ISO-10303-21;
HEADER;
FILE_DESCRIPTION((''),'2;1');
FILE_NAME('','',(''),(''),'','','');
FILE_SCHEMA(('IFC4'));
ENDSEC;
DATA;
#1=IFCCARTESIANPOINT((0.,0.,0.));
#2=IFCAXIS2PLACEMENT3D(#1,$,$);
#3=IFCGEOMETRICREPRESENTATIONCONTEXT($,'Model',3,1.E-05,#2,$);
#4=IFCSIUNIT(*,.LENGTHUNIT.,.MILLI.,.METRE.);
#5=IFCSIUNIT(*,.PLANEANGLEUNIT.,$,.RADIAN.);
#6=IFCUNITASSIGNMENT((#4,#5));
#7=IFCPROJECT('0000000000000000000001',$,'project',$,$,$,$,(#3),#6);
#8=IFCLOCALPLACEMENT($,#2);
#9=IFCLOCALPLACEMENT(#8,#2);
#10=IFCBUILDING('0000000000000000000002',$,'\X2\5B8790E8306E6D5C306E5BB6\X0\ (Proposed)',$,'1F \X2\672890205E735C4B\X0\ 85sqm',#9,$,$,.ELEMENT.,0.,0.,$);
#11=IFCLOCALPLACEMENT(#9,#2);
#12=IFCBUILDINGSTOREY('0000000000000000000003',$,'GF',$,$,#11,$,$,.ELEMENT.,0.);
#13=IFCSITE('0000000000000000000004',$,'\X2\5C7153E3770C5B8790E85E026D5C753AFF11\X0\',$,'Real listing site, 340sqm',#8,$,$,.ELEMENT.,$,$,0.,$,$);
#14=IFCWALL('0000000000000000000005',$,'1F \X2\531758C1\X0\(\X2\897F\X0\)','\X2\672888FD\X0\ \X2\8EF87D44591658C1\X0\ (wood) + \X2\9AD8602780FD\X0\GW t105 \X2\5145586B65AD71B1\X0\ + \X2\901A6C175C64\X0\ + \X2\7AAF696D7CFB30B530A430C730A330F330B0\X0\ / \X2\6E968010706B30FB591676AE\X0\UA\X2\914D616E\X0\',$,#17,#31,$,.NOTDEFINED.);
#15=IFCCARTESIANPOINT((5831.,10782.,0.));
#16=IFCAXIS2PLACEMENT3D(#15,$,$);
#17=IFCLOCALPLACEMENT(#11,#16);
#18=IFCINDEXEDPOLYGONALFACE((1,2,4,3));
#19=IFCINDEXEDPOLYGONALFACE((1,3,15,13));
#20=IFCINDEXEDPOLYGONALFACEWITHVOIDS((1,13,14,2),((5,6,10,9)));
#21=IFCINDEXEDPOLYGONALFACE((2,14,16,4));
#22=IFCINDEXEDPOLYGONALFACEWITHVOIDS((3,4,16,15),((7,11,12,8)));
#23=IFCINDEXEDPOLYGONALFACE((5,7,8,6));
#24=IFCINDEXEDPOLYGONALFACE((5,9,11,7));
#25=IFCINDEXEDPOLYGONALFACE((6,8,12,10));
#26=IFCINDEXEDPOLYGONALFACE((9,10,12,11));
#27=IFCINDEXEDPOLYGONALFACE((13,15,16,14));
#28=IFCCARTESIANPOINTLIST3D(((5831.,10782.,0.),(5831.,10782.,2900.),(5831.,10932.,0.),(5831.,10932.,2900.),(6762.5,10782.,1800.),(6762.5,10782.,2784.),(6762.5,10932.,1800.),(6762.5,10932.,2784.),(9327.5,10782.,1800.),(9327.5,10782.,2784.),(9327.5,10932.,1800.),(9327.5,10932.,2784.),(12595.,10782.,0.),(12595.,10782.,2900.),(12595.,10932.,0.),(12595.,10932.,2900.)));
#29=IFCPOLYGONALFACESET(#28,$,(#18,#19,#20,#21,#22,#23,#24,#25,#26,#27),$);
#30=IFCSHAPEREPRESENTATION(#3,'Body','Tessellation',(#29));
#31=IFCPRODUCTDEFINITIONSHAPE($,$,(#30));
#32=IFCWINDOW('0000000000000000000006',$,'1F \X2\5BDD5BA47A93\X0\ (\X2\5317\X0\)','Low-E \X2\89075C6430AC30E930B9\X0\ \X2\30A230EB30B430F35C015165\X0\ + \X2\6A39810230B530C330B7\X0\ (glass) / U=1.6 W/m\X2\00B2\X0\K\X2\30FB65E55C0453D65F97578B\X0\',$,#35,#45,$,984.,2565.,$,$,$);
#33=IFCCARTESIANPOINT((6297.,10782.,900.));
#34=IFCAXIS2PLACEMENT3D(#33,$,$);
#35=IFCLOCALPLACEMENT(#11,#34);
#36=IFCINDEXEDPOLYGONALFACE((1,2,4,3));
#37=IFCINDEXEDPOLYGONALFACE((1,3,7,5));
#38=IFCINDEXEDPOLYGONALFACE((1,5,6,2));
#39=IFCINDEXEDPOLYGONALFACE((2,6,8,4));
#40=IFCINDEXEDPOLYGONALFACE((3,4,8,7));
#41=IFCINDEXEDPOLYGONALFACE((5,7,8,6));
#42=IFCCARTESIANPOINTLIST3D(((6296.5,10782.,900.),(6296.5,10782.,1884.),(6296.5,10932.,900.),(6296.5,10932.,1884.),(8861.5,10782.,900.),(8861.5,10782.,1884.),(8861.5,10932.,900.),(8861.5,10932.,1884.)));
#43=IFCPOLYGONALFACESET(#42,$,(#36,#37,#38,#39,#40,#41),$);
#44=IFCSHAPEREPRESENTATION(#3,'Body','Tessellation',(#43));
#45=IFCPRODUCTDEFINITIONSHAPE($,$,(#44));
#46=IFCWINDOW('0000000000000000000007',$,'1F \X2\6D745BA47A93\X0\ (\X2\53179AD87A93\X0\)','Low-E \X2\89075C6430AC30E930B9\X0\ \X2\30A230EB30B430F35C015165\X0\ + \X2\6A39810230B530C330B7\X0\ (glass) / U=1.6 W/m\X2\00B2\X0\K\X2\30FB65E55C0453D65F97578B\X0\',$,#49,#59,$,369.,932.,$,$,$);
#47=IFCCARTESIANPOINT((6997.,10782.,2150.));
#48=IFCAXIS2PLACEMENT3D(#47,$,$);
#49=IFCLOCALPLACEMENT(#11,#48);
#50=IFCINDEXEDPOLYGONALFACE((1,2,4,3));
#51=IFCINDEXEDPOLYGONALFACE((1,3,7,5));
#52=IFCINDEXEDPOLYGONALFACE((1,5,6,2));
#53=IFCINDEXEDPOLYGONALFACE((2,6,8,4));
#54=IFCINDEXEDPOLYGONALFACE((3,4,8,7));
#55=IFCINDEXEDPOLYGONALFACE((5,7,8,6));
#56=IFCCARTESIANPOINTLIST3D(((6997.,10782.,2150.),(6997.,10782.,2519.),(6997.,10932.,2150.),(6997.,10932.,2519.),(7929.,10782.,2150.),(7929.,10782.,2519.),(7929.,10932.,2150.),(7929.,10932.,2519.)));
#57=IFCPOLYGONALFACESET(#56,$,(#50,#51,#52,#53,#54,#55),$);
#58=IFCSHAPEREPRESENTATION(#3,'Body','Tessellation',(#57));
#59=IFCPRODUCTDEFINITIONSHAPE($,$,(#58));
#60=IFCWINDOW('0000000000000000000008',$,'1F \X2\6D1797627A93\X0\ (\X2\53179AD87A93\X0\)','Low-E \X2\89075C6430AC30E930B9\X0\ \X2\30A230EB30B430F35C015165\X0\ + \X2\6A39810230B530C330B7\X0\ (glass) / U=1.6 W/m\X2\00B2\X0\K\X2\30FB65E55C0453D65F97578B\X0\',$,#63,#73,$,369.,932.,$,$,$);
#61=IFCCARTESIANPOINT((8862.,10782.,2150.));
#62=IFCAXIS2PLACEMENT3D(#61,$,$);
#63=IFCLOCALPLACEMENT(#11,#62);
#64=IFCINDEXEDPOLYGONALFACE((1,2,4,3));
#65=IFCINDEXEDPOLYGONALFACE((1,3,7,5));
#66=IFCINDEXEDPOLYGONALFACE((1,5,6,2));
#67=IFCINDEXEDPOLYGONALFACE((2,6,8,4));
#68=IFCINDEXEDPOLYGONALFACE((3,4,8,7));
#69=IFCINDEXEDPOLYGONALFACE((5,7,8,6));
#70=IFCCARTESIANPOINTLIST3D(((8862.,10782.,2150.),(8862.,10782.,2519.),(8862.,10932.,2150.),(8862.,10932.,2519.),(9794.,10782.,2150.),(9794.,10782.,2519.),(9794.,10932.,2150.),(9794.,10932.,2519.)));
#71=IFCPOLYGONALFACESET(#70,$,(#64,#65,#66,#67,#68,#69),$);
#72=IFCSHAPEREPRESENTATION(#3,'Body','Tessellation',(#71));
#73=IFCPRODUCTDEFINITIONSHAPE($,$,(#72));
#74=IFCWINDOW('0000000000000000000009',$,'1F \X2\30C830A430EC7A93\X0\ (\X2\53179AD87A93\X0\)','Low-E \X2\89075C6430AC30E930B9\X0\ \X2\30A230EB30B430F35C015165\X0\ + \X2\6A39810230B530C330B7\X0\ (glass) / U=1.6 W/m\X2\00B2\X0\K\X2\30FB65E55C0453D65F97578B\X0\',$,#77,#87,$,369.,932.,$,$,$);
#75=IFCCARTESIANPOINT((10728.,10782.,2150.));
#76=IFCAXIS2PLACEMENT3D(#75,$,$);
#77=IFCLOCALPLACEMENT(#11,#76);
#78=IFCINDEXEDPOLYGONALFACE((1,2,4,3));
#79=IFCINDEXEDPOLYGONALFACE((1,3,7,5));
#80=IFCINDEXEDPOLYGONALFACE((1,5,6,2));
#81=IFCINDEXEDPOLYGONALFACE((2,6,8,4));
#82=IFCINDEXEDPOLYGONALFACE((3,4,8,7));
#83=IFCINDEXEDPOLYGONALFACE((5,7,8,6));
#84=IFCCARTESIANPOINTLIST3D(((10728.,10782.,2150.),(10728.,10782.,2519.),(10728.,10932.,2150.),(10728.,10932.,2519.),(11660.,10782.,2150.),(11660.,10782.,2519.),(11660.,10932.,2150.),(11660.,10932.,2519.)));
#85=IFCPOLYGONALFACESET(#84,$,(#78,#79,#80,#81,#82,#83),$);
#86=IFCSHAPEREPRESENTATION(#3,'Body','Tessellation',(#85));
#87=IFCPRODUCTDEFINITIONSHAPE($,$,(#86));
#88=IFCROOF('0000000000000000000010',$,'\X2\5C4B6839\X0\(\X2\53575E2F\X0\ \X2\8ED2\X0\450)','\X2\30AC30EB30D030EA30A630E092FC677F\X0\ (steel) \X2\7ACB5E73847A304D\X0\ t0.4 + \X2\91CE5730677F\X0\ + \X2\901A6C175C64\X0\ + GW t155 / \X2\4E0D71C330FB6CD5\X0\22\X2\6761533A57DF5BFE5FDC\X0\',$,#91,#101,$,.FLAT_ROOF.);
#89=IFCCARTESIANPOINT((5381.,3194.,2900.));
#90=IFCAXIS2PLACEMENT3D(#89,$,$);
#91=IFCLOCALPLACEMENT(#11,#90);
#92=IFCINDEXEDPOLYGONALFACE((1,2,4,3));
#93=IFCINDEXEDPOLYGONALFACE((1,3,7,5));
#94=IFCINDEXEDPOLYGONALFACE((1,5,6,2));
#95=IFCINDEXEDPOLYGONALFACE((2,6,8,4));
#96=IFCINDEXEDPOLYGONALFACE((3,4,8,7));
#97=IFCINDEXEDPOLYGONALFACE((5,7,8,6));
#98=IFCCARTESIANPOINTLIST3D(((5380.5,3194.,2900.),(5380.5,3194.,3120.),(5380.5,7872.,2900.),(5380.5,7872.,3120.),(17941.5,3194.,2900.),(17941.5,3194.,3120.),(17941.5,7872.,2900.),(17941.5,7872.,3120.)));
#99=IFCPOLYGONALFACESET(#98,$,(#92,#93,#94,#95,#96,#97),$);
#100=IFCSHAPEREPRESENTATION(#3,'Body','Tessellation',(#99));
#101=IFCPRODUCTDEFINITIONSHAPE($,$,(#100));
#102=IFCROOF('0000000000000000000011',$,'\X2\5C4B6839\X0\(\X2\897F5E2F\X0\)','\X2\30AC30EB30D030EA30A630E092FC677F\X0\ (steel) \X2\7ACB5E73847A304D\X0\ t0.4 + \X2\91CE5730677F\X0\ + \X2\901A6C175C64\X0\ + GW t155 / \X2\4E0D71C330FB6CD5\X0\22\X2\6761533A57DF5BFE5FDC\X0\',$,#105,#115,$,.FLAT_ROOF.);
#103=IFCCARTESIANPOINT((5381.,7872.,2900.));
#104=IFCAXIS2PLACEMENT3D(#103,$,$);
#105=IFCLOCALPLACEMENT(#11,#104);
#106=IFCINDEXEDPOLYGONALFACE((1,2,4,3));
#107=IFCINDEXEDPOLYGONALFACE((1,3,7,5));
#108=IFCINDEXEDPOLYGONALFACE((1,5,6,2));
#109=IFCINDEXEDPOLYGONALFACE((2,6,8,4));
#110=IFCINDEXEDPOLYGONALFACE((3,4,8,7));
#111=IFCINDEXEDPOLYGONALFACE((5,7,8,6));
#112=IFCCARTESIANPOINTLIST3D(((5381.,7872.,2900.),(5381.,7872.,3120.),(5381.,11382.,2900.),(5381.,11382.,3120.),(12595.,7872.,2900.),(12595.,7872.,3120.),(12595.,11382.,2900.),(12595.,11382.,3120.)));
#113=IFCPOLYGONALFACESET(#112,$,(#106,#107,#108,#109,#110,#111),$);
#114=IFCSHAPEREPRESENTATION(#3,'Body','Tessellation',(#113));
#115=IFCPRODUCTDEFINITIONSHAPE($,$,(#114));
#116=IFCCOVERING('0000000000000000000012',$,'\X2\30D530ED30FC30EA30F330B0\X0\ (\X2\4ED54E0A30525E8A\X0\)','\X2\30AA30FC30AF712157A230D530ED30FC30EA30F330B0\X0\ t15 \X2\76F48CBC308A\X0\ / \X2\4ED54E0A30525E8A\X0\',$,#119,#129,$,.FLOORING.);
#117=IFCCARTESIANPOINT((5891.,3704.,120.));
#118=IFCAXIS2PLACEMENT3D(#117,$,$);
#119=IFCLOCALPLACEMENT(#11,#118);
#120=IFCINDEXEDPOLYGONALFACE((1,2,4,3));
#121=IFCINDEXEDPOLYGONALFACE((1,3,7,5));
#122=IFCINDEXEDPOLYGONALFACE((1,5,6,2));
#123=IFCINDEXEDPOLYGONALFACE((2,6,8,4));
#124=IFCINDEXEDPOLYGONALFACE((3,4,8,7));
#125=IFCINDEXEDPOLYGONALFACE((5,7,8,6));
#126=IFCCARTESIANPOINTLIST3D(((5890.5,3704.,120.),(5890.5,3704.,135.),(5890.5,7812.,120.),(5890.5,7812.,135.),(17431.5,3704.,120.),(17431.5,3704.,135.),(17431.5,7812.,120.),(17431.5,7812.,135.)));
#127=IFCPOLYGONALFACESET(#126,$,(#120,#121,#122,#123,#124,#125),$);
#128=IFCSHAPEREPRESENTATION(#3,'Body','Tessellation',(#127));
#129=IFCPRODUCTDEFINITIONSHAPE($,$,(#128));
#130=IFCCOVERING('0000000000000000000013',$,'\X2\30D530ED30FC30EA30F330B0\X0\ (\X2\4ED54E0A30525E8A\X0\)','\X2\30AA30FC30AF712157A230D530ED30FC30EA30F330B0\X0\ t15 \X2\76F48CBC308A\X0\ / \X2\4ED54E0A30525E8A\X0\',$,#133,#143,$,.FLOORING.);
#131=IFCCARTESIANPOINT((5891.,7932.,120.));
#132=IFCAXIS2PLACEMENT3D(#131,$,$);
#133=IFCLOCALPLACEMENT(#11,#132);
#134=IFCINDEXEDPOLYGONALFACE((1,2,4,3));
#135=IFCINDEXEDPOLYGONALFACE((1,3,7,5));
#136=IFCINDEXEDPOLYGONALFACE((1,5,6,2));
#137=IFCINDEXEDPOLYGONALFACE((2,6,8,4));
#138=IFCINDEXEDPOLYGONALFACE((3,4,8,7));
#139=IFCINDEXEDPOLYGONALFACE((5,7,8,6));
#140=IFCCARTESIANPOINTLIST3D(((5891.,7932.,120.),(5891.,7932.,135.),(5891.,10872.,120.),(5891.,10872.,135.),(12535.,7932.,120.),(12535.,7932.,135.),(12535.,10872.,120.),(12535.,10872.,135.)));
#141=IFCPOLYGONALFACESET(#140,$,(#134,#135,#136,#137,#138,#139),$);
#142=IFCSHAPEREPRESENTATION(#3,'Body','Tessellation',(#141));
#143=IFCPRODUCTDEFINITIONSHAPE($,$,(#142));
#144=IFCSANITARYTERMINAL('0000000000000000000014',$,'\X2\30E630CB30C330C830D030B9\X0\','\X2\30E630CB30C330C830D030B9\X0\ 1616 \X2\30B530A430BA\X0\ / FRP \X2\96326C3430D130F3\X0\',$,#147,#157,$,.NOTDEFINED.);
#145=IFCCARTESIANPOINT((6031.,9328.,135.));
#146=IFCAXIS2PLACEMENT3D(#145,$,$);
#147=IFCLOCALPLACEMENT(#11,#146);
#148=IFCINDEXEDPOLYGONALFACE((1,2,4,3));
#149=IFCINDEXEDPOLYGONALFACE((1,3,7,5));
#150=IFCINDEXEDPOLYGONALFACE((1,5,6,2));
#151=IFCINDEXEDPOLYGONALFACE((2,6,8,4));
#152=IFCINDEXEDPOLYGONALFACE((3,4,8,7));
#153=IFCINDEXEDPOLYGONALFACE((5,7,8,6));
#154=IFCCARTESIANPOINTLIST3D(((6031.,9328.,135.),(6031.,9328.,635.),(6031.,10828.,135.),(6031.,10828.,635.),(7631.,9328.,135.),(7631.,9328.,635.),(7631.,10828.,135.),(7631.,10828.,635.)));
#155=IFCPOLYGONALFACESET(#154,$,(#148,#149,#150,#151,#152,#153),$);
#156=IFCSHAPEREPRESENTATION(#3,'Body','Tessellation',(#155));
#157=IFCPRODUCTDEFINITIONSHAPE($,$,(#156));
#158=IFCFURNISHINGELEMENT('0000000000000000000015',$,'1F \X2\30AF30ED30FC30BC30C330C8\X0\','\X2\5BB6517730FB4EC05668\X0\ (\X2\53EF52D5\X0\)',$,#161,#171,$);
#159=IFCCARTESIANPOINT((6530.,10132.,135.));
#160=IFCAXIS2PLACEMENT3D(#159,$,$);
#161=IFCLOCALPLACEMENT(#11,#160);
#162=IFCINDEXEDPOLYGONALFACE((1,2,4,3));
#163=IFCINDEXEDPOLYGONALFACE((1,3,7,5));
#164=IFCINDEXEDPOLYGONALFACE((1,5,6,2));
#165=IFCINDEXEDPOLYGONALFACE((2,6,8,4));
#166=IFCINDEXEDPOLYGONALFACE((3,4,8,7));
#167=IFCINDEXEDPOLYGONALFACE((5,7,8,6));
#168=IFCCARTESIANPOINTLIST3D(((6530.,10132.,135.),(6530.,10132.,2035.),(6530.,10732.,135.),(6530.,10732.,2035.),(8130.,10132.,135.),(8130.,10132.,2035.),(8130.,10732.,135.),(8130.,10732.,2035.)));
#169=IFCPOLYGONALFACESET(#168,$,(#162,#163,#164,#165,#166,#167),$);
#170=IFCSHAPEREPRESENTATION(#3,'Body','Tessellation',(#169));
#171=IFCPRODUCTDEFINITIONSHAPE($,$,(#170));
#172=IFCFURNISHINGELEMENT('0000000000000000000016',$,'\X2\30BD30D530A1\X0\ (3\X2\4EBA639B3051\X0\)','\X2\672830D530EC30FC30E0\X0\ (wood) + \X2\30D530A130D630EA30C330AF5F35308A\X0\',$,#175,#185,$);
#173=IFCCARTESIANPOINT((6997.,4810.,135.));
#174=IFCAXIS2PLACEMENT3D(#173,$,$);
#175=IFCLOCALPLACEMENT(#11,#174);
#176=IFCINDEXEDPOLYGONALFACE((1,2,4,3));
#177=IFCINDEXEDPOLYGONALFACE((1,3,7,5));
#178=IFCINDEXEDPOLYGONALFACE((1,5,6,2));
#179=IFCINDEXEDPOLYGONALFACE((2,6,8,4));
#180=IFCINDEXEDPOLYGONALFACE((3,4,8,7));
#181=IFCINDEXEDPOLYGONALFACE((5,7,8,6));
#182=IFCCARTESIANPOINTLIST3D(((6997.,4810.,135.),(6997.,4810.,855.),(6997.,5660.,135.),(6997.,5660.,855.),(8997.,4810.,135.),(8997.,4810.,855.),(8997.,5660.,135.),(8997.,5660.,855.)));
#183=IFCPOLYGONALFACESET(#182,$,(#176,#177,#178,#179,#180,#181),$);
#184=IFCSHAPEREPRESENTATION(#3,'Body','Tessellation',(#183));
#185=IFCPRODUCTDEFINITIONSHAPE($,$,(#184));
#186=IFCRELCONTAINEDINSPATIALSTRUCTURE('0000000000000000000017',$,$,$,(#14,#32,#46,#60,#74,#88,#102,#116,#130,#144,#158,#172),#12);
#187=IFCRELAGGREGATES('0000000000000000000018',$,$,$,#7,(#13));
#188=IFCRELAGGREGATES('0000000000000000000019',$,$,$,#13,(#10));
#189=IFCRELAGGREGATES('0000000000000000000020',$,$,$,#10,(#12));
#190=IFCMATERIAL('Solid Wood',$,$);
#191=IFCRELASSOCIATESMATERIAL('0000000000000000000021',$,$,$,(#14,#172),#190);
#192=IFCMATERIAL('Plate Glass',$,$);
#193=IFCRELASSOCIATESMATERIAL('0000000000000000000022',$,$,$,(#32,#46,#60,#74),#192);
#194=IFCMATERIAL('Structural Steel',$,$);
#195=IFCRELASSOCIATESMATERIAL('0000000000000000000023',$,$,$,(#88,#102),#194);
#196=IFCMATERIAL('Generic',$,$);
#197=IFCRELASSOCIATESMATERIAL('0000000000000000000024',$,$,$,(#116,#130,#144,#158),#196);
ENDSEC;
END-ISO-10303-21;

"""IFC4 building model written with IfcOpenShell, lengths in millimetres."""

from ifc_helpers import new_model, si_unit, frame, frame_2d, origin, place, context, project, spatial, rectangle, extrude, material, element, fill, save


model = new_model("IFC4")

# Units and contexts
model_context = context("Model", 3, precision=1e-05, world=origin())
ifc_project = project(units=[si_unit("LENGTHUNIT", "METRE", prefix="MILLI"), si_unit("PLANEANGLEUNIT", "RADIAN")], contexts=[model_context])

# Site, building, storey
site_placement = place(None, origin())
site = spatial("IfcSite", under=ifc_project, at=site_placement, Name="山口県宇部市浜町１", ObjectType="Real listing site, 340sqm", CompositionType="ELEMENT", RefElevation=0.0)
building_placement = place(site_placement, origin())
building = spatial("IfcBuilding", under=site, at=building_placement, Name="宇部の浜の家 (Proposed)", ObjectType="1F 木造平屋 85sqm", CompositionType="ELEMENT", ElevationOfRefHeight=0.0, ElevationOfTerrain=0.0)
storey_placement = place(building_placement, origin())
storey = spatial("IfcBuildingStorey", under=building, at=storey_placement, Name="GF", CompositionType="ELEMENT", Elevation=0.0)

# Shared definitions
ifc_material_1 = material(Name="Solid Wood")

# Shared definitions
ifc_material_2 = material(Name="Plate Glass")

# Wall, openings, windows
wall_1_placement = place(storey_placement, frame((5831.0, 10782.0, 0.0)))
wall_1 = element("IfcWall", 1, at=wall_1_placement, inside=storey, material=ifc_material_1, Name="1F 北壁(西)", Description="木製 軸組外壁 (wood) + 高性能GW t105 充填断熱 + 通気層 + 窯業系サイディング / 準耐火・外皮UA配慮", PredefinedType="NOTDEFINED", context=model_context, shape_type="SweptSolid", body=[
    extrude(rectangle(XDim=6764.0, YDim=150.0, at=frame_2d((3382.0, 75.0))), frame((5831.0, 10782.0, 0.0)), (0.0, 0.0, 1.0), 2900.0),
])
opening_1_placement = place(storey_placement, frame((6297.0, 10782.0, 900.0)))
opening_1 = element("IfcOpeningElement", 2, at=opening_1_placement, cuts=wall_1, PredefinedType="NOTDEFINED", context=model_context, shape_type="SweptSolid", body=[
    extrude(rectangle(XDim=2565.0, YDim=150.0, at=frame_2d((1282.0, 75.0))), frame((6297.0, 10782.0, 900.0)), (0.0, 0.0, 1.0), 984.0),
])
opening_2_placement = place(storey_placement, frame((6997.0, 10782.0, 2150.0)))
opening_2 = element("IfcOpeningElement", 3, at=opening_2_placement, cuts=wall_1, PredefinedType="NOTDEFINED", context=model_context, shape_type="SweptSolid", body=[
    extrude(rectangle(XDim=932.0, YDim=150.0, at=frame_2d((466.0, 75.0))), frame((6997.0, 10782.0, 2150.0)), (0.0, 0.0, 1.0), 369.0),
])
opening_3_placement = place(storey_placement, frame((8862.0, 10782.0, 2150.0)))
opening_3 = element("IfcOpeningElement", 4, at=opening_3_placement, cuts=wall_1, PredefinedType="NOTDEFINED", context=model_context, shape_type="SweptSolid", body=[
    extrude(rectangle(XDim=932.0, YDim=150.0, at=frame_2d((466.0, 75.0))), frame((8862.0, 10782.0, 2150.0)), (0.0, 0.0, 1.0), 369.0),
])
opening_4_placement = place(storey_placement, frame((10728.0, 10782.0, 2150.0)))
opening_4 = element("IfcOpeningElement", 5, at=opening_4_placement, cuts=wall_1, PredefinedType="NOTDEFINED", context=model_context, shape_type="SweptSolid", body=[
    extrude(rectangle(XDim=932.0, YDim=150.0, at=frame_2d((466.0, 75.0))), frame((10728.0, 10782.0, 2150.0)), (0.0, 0.0, 1.0), 369.0),
])
window_1_placement = place(storey_placement, frame((6297.0, 10782.0, 900.0)))
window_1 = element("IfcWindow", 6, at=window_1_placement, inside=storey, material=ifc_material_2, Name="1F 寝室窓 (北)", Description="Low-E 複層ガラス アルゴン封入 + 樹脂サッシ (glass) / U=1.6 W/m²K・日射取得型", OverallHeight=984.0, OverallWidth=2565.0, context=model_context, shape_type="SweptSolid", body=[
    extrude(rectangle(XDim=2565.0, YDim=150.0, at=frame_2d((1282.0, 75.0))), frame((6297.0, 10782.0, 900.0)), (0.0, 0.0, 1.0), 984.0),
])
fill(opening_1, window_1)
window_2_placement = place(storey_placement, frame((6997.0, 10782.0, 2150.0)))
window_2 = element("IfcWindow", 7, at=window_2_placement, inside=storey, material=ifc_material_2, Name="1F 浴室窓 (北高窓)", Description="Low-E 複層ガラス アルゴン封入 + 樹脂サッシ (glass) / U=1.6 W/m²K・日射取得型", OverallHeight=369.0, OverallWidth=932.0, context=model_context, shape_type="SweptSolid", body=[
    extrude(rectangle(XDim=932.0, YDim=150.0, at=frame_2d((466.0, 75.0))), frame((6997.0, 10782.0, 2150.0)), (0.0, 0.0, 1.0), 369.0),
])
fill(opening_2, window_2)
window_3_placement = place(storey_placement, frame((8862.0, 10782.0, 2150.0)))
window_3 = element("IfcWindow", 8, at=window_3_placement, inside=storey, material=ifc_material_2, Name="1F 洗面窓 (北高窓)", Description="Low-E 複層ガラス アルゴン封入 + 樹脂サッシ (glass) / U=1.6 W/m²K・日射取得型", OverallHeight=369.0, OverallWidth=932.0, context=model_context, shape_type="SweptSolid", body=[
    extrude(rectangle(XDim=932.0, YDim=150.0, at=frame_2d((466.0, 75.0))), frame((8862.0, 10782.0, 2150.0)), (0.0, 0.0, 1.0), 369.0),
])
fill(opening_3, window_3)
window_4_placement = place(storey_placement, frame((10728.0, 10782.0, 2150.0)))
window_4 = element("IfcWindow", 9, at=window_4_placement, inside=storey, material=ifc_material_2, Name="1F トイレ窓 (北高窓)", Description="Low-E 複層ガラス アルゴン封入 + 樹脂サッシ (glass) / U=1.6 W/m²K・日射取得型", OverallHeight=369.0, OverallWidth=932.0, context=model_context, shape_type="SweptSolid", body=[
    extrude(rectangle(XDim=932.0, YDim=150.0, at=frame_2d((466.0, 75.0))), frame((10728.0, 10782.0, 2150.0)), (0.0, 0.0, 1.0), 369.0),
])
fill(opening_4, window_4)

# Roofs
ifc_material_3 = material(Name="Structural Steel")
roof_1_placement = place(storey_placement, frame((5381.0, 3194.0, 2900.0)))
element("IfcRoof", 10, at=roof_1_placement, inside=storey, material=ifc_material_3, Name="屋根(南帯 軒450)", Description="ガルバリウム鋼板 (steel) 立平葺き t0.4 + 野地板 + 通気層 + GW t155 / 不燃・法22条区域対応", PredefinedType="FLAT_ROOF", context=model_context, shape_type="SweptSolid", body=[
    extrude(rectangle(XDim=12561.0, YDim=4678.0, at=frame_2d((6280.0, 2339.0))), frame((5381.0, 3194.0, 2900.0)), (0.0, 0.0, 1.0), 220.0),
])
roof_2_placement = place(storey_placement, frame((5381.0, 7872.0, 2900.0)))
element("IfcRoof", 11, at=roof_2_placement, inside=storey, material=ifc_material_3, Name="屋根(西帯)", Description="ガルバリウム鋼板 (steel) 立平葺き t0.4 + 野地板 + 通気層 + GW t155 / 不燃・法22条区域対応", PredefinedType="FLAT_ROOF", context=model_context, shape_type="SweptSolid", body=[
    extrude(rectangle(XDim=7214.0, YDim=3510.0, at=frame_2d((3607.0, 1755.0))), frame((5381.0, 7872.0, 2900.0)), (0.0, 0.0, 1.0), 220.0),
])

# Coverings
ifc_material_4 = material(Name="Generic")
covering_1_placement = place(storey_placement, frame((5891.0, 3704.0, 120.0)))
element("IfcCovering", 12, at=covering_1_placement, inside=storey, material=ifc_material_4, Name="フローリング (仕上げ床)", Description="オーク無垢フローリング t15 直貼り / 仕上げ床", PredefinedType="FLOORING", context=model_context, shape_type="SweptSolid", body=[
    extrude(rectangle(XDim=11541.0, YDim=4108.0, at=frame_2d((5770.0, 2054.0))), frame((5891.0, 3704.0, 120.0)), (0.0, 0.0, 1.0), 15.0),
])
covering_2_placement = place(storey_placement, frame((5891.0, 7932.0, 120.0)))
element("IfcCovering", 13, at=covering_2_placement, inside=storey, material=ifc_material_4, Name="フローリング (仕上げ床)", Description="オーク無垢フローリング t15 直貼り / 仕上げ床", PredefinedType="FLOORING", context=model_context, shape_type="SweptSolid", body=[
    extrude(rectangle(XDim=6644.0, YDim=2940.0, at=frame_2d((3322.0, 1470.0))), frame((5891.0, 7932.0, 120.0)), (0.0, 0.0, 1.0), 15.0),
])

# Sanitary terminal
sanitary_terminal_placement = place(storey_placement, frame((6031.0, 9328.0, 135.0)))
element("IfcSanitaryTerminal", 14, at=sanitary_terminal_placement, inside=storey, material=ifc_material_4, Name="ユニットバス", Description="ユニットバス 1616 サイズ / FRP 防水パン", PredefinedType="NOTDEFINED", context=model_context, shape_type="SweptSolid", body=[
    extrude(rectangle(XDim=1600.0, YDim=1500.0, at=frame_2d((800.0, 750.0))), frame((6031.0, 9328.0, 135.0)), (0.0, 0.0, 1.0), 500.0),
])

# Furnishing elements
furnishing_1_placement = place(storey_placement, frame((6530.0, 10132.0, 135.0)))
element("IfcFurnishingElement", 15, at=furnishing_1_placement, inside=storey, material=ifc_material_4, Name="1F クローゼット", Description="家具・什器 (可動)", context=model_context, shape_type="SweptSolid", body=[
    extrude(rectangle(XDim=1600.0, YDim=600.0, at=frame_2d((800.0, 300.0))), frame((6530.0, 10132.0, 135.0)), (0.0, 0.0, 1.0), 1900.0),
])
furnishing_2_placement = place(storey_placement, frame((6997.0, 4810.0, 135.0)))
element("IfcFurnishingElement", 16, at=furnishing_2_placement, inside=storey, material=ifc_material_1, Name="ソファ (3人掛け)", Description="木フレーム (wood) + ファブリック張り", context=model_context, shape_type="SweptSolid", body=[
    extrude(rectangle(XDim=2000.0, YDim=850.0, at=frame_2d((1000.0, 425.0))), frame((6997.0, 4810.0, 135.0)), (0.0, 0.0, 1.0), 720.0),
])

save(model, "model.ifc")
